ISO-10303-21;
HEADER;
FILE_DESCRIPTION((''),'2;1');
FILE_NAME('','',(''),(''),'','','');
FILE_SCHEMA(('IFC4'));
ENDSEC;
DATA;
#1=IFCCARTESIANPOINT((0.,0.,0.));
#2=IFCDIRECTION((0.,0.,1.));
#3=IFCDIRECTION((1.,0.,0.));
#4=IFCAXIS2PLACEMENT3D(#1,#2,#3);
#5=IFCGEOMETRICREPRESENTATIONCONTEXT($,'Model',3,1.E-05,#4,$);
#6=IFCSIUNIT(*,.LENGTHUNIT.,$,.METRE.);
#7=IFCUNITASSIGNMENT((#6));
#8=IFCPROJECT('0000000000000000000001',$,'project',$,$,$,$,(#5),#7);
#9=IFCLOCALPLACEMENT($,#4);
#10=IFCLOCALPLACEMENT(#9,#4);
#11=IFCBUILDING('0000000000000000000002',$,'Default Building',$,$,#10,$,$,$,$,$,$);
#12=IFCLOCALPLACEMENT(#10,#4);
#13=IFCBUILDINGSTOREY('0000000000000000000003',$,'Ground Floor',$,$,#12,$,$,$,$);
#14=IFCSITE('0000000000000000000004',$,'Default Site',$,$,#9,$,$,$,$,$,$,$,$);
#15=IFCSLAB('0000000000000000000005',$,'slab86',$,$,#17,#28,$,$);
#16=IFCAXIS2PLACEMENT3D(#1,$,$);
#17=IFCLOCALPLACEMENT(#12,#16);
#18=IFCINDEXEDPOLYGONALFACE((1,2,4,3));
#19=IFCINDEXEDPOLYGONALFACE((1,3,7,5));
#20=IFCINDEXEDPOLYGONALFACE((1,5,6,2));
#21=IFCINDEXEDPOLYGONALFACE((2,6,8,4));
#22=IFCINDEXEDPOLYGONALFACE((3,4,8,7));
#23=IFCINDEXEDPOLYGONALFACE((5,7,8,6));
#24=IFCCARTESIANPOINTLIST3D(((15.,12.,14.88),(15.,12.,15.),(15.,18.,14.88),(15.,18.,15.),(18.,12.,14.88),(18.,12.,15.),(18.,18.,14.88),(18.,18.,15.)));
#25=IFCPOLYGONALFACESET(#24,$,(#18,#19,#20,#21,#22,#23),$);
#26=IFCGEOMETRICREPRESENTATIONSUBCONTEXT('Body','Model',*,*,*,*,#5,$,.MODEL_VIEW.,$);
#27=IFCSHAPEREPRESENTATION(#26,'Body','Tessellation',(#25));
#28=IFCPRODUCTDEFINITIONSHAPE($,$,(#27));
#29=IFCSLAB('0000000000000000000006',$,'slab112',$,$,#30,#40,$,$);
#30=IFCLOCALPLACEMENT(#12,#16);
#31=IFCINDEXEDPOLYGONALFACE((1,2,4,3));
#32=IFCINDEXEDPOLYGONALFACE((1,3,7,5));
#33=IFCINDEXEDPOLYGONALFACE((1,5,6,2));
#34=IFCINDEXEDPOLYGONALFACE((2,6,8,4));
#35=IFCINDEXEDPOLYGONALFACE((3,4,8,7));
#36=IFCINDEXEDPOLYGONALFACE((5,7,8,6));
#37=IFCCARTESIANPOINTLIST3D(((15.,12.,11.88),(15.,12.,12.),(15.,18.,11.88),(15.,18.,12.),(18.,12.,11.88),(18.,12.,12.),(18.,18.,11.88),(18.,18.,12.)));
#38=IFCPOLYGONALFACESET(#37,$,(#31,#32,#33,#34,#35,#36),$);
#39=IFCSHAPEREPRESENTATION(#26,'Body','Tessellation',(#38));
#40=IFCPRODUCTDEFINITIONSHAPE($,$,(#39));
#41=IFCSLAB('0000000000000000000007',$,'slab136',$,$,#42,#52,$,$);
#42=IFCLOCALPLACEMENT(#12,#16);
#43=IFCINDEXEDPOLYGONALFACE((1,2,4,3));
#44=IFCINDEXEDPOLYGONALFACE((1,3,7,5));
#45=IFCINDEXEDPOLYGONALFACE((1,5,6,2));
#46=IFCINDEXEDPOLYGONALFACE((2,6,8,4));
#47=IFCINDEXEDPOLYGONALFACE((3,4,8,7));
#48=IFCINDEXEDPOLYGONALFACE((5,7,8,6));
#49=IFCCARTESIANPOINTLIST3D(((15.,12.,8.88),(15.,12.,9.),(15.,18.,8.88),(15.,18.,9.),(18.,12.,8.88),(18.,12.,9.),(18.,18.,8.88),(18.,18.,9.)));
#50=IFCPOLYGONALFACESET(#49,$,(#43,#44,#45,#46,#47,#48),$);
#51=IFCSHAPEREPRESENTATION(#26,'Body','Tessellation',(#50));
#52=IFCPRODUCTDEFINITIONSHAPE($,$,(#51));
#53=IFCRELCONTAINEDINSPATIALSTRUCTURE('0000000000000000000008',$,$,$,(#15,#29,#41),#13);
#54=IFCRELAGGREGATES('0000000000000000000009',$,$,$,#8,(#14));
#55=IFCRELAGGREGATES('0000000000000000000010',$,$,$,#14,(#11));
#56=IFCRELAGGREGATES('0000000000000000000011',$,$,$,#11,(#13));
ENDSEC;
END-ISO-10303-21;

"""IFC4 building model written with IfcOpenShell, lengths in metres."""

from ifc_helpers import new_model, si_unit, frame, origin_with_axes, place, context, subcontext, project, spatial, indexed_curve, outline, extrude, element, save


model = new_model("IFC4")

# Units and contexts
model_context = context("Model", 3, precision=1e-05, world=origin_with_axes())
body_context = subcontext(model_context, "Body", "Model", "MODEL_VIEW")
ifc_project = project(units=[si_unit("LENGTHUNIT", "METRE")], contexts=[model_context])

# Site, building, storey
site_placement = place(None, origin_with_axes())
site = spatial("IfcSite", under=ifc_project, at=site_placement, Name="Default Site")
building_placement = place(site_placement, origin_with_axes())
building = spatial("IfcBuilding", under=site, at=building_placement, Name="Default Building")
storey_placement = place(building_placement, origin_with_axes())
storey = spatial("IfcBuildingStorey", under=building, at=storey_placement, Name="Ground Floor")

# Slabs
for number, where, z_axis, x_axis, name in (
    (1, (15.0, 12.0, 14.88), (0.0, 0.0, 1.0), (1.0, 0.0, 0.0), "slab86"),
    (2, (15.0, 12.0, 11.88), (0.0, 0.0, 1.0), (1.0, 0.0, 0.0), "slab112"),
    (3, (15.0, 12.0, 8.88), (0.0, 0.0, 1.0), (1.0, 0.0, 0.0), "slab136"),
):
    element("IfcSlab", number, at=place(storey_placement, frame(where, z_axis=z_axis, x_axis=x_axis)), inside=storey, Name=name, context=body_context, shape_type="SweptSolid", body=[
        extrude(outline(indexed_curve([(0.0, 0.0), (0.0, 6.0), (3.0, 6.0), (3.0, 0.0), (0.0, 0.0)], self_intersect=False)), origin_with_axes(), (0.0, 0.0, 1.0), 0.12),
    ])

save(model, "model.ifc")
